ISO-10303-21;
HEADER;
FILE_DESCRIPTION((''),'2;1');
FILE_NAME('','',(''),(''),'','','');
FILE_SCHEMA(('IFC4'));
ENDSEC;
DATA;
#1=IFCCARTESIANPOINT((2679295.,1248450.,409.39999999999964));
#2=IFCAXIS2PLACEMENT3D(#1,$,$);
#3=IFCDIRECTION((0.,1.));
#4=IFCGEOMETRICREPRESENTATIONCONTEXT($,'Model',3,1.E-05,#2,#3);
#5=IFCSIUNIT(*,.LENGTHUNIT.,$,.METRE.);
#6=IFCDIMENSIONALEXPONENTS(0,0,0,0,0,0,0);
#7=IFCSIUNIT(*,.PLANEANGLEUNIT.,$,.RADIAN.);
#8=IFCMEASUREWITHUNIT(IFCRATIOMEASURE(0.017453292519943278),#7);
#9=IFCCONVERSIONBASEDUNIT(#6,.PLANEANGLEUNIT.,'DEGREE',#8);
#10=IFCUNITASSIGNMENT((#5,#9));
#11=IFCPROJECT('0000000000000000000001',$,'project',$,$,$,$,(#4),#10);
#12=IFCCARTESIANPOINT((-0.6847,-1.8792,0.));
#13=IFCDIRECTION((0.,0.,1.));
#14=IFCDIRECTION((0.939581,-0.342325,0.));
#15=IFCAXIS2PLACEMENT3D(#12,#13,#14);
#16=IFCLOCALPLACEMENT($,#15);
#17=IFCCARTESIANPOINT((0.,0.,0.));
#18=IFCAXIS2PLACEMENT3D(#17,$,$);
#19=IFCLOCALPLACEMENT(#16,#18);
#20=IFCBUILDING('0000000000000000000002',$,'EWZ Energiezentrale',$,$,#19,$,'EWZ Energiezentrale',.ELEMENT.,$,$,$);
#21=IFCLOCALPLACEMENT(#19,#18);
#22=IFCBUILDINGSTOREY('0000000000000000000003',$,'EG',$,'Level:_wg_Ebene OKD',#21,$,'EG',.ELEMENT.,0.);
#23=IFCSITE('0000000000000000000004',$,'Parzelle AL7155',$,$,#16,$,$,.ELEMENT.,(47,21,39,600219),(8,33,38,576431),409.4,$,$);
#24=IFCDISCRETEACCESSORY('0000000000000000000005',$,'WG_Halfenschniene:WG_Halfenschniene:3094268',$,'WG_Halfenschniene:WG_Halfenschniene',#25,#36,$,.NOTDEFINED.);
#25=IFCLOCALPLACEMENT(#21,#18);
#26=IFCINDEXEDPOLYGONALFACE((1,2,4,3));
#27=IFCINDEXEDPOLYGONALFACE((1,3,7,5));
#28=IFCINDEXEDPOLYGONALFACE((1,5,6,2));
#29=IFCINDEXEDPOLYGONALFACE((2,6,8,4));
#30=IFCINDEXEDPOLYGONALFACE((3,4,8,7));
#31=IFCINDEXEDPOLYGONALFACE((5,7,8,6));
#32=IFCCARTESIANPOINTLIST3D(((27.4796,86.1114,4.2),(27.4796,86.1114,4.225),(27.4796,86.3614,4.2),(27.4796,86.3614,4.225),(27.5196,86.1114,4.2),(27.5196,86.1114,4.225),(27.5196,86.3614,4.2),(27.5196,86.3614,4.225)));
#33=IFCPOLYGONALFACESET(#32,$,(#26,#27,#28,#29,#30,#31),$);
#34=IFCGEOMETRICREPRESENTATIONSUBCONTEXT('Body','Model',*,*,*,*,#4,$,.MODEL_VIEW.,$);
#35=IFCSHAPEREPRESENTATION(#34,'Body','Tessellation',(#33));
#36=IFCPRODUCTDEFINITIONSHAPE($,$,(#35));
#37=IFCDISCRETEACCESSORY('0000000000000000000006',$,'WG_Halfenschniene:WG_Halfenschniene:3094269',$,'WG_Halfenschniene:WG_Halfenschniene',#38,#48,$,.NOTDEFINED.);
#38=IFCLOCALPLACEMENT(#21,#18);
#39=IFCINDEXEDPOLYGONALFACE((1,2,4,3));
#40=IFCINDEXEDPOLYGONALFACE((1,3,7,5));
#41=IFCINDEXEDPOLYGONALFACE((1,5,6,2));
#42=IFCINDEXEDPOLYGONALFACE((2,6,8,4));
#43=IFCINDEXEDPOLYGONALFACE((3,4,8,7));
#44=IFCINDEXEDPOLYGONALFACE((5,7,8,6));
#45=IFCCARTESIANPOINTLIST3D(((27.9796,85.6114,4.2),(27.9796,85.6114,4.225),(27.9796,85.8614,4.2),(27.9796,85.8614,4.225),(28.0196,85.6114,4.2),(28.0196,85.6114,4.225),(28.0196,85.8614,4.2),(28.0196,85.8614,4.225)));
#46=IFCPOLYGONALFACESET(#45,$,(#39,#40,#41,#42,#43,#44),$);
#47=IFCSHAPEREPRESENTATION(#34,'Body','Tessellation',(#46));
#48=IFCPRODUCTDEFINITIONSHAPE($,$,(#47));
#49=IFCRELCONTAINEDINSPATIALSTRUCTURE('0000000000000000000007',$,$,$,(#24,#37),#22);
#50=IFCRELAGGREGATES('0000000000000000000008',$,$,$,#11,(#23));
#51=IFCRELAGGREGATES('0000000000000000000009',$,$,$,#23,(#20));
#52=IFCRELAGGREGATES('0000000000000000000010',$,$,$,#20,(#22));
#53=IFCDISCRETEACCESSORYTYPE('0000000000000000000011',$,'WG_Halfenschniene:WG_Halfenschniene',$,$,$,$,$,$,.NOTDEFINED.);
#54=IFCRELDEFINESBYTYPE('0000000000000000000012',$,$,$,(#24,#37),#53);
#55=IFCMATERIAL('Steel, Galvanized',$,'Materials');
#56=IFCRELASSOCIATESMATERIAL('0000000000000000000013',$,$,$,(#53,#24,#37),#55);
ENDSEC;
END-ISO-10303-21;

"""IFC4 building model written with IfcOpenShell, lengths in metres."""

from ifc_helpers import new_model, entity, si_unit, converted_unit, direction, frame, origin, place, context, subcontext, project, spatial, indexed_curve, outline, extrude, source, transform, mapped, material, type_object, element, save


model = new_model("IFC4")

# Units and contexts
model_context = context("Model", 3, precision=1e-05, world=frame((2679295.0, 1248450.0, 409.39999999999964)), true_north=direction((0.0, 1.0)))
body_context = subcontext(model_context, "Body", "Model", "MODEL_VIEW")
ifc_project = project(units=[si_unit("LENGTHUNIT", "METRE"), converted_unit("PLANEANGLEUNIT", "DEGREE", entity("IfcRatioMeasure", 0.017453292519943278), si_unit("PLANEANGLEUNIT", "RADIAN"), dimensions=[0, 0, 0, 0, 0, 0, 0])], contexts=[model_context])

# Site, building, storey
site_placement = place(None, frame((-0.6847, -1.8792, 0.0), z_axis=(0.0, 0.0, 1.0), x_axis=(0.939581, -0.342325, 0.0)))
site = spatial("IfcSite", under=ifc_project, at=site_placement, Name="Parzelle AL7155", CompositionType="ELEMENT", RefLatitude=(47, 21, 39, 600219), RefLongitude=(8, 33, 38, 576431), RefElevation=409.4)
building_placement = place(site_placement, origin())
building = spatial("IfcBuilding", under=site, at=building_placement, Name="EWZ Energiezentrale", LongName="EWZ Energiezentrale", CompositionType="ELEMENT")
storey_placement = place(building_placement, origin())
storey = spatial("IfcBuildingStorey", under=building, at=storey_placement, Name="EG", ObjectType="Level:_wg_Ebene OKD", LongName="EG", CompositionType="ELEMENT", Elevation=0.0)

# Discrete accessories
ifc_material = material(Name="Steel, Galvanized", Category="Materials")
discrete_accessory_type = type_object("IfcDiscreteAccessoryType", Name="WG_Halfenschniene:WG_Halfenschniene", PredefinedType="NOTDEFINED", material=ifc_material)
shared_shape = source(origin(), body_context, "Body", "SweptSolid", [
    extrude(outline(indexed_curve([(-0.125, -0.02), (0.125, -0.02), (0.125, 0.02), (-0.125, 0.02), (-0.125, -0.02)], self_intersect=False)), frame((0.125, 0.0, -0.0125)), (0.0, 0.0, 1.0), 0.025),
])
for number, where, z_axis, x_axis, name in (
    (1, (27.4996, 86.1114, 4.2125), (0.0, 0.0, -1.0), (0.0, 1.0, 0.0), "WG_Halfenschniene:WG_Halfenschniene:3094268"),
    (2, (27.9996, 85.6114, 4.2125), (0.0, 0.0, -1.0), (0.0, 1.0, 0.0), "WG_Halfenschniene:WG_Halfenschniene:3094269"),
):
    element("IfcDiscreteAccessory", number, at=place(storey_placement, frame(where, z_axis=z_axis, x_axis=x_axis)), inside=storey, type_object=discrete_accessory_type, material=ifc_material, Name=name, ObjectType="WG_Halfenschniene:WG_Halfenschniene", PredefinedType="NOTDEFINED", context=body_context, shape_type="MappedRepresentation", body=[
        mapped(shared_shape, transform((0.0, 0.0, 0.0), scale=1.0)),
    ])

save(model, "model.ifc")
